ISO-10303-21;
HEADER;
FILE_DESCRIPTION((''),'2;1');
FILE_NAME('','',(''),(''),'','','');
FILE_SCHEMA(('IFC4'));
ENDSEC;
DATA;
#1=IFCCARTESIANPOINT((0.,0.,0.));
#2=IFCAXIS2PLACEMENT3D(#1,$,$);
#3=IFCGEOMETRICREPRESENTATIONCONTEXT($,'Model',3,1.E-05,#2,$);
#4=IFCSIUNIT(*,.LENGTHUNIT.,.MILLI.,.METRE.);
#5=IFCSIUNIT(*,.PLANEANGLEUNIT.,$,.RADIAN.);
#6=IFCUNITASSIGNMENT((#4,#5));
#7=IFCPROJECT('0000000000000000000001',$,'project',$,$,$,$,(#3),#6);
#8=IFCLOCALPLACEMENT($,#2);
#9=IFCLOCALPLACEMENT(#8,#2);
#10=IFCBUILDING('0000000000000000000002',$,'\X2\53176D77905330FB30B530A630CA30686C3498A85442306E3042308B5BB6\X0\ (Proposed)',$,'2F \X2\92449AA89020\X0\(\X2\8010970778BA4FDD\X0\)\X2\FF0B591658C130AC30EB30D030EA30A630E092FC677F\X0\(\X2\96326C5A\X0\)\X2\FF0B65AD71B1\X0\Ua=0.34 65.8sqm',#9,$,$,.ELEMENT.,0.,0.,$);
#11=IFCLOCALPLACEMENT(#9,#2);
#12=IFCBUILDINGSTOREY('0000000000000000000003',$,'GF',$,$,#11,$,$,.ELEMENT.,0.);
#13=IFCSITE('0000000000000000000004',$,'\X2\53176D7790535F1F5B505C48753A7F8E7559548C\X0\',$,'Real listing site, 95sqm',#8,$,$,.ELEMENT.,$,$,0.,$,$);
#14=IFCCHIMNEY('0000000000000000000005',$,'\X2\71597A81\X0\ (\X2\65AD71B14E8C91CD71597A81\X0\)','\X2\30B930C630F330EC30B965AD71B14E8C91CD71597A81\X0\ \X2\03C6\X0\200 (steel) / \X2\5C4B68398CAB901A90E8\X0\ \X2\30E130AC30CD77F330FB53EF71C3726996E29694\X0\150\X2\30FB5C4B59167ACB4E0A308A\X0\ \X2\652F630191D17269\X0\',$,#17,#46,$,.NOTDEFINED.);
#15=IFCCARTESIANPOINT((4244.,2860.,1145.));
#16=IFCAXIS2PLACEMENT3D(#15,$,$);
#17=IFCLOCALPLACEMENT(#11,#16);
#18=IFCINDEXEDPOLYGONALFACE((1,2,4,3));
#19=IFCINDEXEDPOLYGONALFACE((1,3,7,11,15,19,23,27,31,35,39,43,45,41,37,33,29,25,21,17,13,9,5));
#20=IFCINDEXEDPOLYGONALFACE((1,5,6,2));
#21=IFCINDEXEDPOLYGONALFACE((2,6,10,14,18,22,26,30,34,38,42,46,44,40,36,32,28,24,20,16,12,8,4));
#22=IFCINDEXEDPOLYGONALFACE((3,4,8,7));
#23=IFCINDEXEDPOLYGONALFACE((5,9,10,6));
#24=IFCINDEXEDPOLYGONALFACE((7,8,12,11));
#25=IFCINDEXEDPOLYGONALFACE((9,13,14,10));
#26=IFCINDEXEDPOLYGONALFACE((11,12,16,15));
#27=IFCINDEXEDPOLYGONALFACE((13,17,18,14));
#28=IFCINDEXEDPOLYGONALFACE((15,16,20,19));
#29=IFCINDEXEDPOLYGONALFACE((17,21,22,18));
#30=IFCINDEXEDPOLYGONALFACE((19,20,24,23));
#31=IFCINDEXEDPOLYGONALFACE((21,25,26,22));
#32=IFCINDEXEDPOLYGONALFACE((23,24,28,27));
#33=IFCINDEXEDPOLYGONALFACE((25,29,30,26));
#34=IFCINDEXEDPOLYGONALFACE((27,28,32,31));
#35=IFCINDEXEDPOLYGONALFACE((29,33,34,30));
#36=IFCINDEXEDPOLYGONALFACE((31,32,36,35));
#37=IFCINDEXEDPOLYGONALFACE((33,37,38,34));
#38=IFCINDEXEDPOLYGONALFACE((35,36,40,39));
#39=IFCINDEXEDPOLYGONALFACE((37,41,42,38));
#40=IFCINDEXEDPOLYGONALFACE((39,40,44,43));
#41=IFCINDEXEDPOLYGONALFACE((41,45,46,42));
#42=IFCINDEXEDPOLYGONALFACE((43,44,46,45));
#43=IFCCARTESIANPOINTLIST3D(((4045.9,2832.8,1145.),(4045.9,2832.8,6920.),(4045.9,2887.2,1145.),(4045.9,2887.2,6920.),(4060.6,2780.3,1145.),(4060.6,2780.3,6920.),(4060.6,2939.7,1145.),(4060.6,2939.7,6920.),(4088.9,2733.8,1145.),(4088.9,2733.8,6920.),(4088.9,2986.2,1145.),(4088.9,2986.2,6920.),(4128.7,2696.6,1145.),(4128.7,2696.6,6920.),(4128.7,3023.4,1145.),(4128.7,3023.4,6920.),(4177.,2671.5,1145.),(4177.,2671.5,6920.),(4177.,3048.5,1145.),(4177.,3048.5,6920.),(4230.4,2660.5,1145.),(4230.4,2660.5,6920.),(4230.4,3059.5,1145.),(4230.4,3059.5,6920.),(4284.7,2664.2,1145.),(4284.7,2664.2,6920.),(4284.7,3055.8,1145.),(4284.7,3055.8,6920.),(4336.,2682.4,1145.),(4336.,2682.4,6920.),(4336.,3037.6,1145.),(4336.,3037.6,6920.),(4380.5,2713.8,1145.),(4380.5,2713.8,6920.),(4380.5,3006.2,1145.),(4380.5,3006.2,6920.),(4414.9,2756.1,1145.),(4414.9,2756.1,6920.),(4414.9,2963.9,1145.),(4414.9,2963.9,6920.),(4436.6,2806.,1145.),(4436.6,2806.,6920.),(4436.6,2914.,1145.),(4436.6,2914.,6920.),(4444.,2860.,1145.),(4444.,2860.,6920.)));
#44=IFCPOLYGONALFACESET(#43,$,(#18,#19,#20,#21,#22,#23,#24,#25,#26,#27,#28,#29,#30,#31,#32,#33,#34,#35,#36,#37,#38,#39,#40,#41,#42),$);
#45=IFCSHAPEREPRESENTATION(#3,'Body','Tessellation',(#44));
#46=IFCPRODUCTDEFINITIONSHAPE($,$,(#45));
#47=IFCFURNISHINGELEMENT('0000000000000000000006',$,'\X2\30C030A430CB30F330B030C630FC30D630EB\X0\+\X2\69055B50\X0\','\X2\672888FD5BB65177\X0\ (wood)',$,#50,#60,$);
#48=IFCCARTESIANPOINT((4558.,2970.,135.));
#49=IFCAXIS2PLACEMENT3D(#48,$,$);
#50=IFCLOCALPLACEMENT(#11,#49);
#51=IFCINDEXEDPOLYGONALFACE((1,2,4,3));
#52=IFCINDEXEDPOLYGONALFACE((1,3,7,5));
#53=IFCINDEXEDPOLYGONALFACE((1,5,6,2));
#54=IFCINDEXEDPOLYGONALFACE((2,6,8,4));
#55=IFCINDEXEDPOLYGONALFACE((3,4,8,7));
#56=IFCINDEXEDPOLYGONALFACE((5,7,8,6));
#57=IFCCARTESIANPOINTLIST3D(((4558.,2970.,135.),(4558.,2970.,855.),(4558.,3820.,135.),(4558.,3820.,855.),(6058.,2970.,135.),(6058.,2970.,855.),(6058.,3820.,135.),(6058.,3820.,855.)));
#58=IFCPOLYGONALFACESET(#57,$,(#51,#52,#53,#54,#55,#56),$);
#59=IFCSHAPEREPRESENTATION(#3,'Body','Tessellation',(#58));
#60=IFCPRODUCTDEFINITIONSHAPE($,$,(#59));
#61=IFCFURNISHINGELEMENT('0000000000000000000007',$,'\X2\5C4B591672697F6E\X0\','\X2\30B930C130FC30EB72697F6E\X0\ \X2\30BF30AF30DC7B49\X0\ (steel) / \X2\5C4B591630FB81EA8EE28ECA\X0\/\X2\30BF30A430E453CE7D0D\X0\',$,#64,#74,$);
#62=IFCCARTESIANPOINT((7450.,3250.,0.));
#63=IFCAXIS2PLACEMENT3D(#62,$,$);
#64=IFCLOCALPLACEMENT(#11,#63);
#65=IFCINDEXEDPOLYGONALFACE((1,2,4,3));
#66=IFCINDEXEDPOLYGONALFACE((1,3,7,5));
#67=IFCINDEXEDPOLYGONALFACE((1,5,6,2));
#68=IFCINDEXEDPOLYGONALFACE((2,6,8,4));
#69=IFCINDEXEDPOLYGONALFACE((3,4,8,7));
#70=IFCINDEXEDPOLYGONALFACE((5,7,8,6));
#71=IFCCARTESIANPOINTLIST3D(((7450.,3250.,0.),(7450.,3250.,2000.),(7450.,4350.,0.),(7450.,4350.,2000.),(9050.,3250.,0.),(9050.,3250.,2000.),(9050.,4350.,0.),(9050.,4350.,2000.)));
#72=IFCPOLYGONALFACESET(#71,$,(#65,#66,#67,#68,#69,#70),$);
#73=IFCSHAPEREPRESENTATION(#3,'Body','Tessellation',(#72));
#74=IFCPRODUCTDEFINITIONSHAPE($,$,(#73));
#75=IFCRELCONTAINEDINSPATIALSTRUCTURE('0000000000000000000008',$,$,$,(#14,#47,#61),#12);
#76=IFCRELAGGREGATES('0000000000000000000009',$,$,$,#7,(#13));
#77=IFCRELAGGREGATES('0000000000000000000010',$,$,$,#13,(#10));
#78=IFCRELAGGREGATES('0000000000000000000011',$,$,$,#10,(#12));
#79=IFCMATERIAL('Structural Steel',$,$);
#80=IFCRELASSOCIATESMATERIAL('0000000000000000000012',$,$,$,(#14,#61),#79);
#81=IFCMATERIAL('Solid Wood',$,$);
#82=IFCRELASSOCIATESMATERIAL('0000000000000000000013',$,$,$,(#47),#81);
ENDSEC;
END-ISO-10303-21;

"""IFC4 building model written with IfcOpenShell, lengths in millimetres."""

from ifc_helpers import new_model, si_unit, frame, frame_2d, origin, origin_2d, place, context, project, spatial, rectangle, circle, extrude, material, element, save


model = new_model("IFC4")

# Units and contexts
model_context = context("Model", 3, precision=1e-05, world=origin())
ifc_project = project(units=[si_unit("LENGTHUNIT", "METRE", prefix="MILLI"), si_unit("PLANEANGLEUNIT", "RADIAN")], contexts=[model_context])

# Site, building, storey
site_placement = place(None, origin())
site = spatial("IfcSite", under=ifc_project, at=site_placement, Name="北海道弟子屈町美留和", ObjectType="Real listing site, 95sqm", CompositionType="ELEMENT", RefElevation=0.0)
building_placement = place(site_placement, origin())
building = spatial("IfcBuilding", under=site, at=building_placement, Name="北海道・サウナと水風呂のある家 (Proposed)", ObjectType="2F 鉄骨造(耐震確保)＋外壁ガルバリウム鋼板(防汚)＋断熱Ua=0.34 65.8sqm", CompositionType="ELEMENT", ElevationOfRefHeight=0.0, ElevationOfTerrain=0.0)
storey_placement = place(building_placement, origin())
storey = spatial("IfcBuildingStorey", under=building, at=storey_placement, Name="GF", CompositionType="ELEMENT", Elevation=0.0)

# Shared definitions
ifc_material_1 = material(Name="Solid Wood")

# Shared definitions
ifc_material_2 = material(Name="Structural Steel")

# Chimney
chimney_placement = place(storey_placement, frame((4244.0, 2860.0, 1145.0)))
element("IfcChimney", 1, at=chimney_placement, inside=storey, material=ifc_material_2, Name="煙突 (断熱二重煙突)", Description="ステンレス断熱二重煙突 φ200 (steel) / 屋根貫通部 メガネ石・可燃物離隔150・屋外立上り 支持金物", PredefinedType="NOTDEFINED", context=model_context, shape_type="SweptSolid", body=[
    extrude(circle(Radius=200.0, at=origin_2d()), frame((4244.0, 2860.0, 1145.0)), (0.0, 0.0, 1.0), 5775.0),
])

# Furnishing elements
furnishing_1_placement = place(storey_placement, frame((4558.0, 2970.0, 135.0)))
element("IfcFurnishingElement", 2, at=furnishing_1_placement, inside=storey, material=ifc_material_1, Name="ダイニングテーブル+椅子", Description="木製家具 (wood)", context=model_context, shape_type="SweptSolid", body=[
    extrude(rectangle(XDim=1500.0, YDim=850.0, at=frame_2d((750.0, 425.0))), frame((4558.0, 2970.0, 135.0)), (0.0, 0.0, 1.0), 720.0),
])
furnishing_2_placement = place(storey_placement, frame((7450.0, 3250.0, 0.0)))
element("IfcFurnishingElement", 3, at=furnishing_2_placement, inside=storey, material=ifc_material_2, Name="屋外物置", Description="スチール物置 タクボ等 (steel) / 屋外・自転車/タイヤ収納", context=model_context, shape_type="SweptSolid", body=[
    extrude(rectangle(XDim=1600.0, YDim=1100.0, at=frame_2d((800.0, 550.0))), frame((7450.0, 3250.0, 0.0)), (0.0, 0.0, 1.0), 2000.0),
])

save(model, "model.ifc")
